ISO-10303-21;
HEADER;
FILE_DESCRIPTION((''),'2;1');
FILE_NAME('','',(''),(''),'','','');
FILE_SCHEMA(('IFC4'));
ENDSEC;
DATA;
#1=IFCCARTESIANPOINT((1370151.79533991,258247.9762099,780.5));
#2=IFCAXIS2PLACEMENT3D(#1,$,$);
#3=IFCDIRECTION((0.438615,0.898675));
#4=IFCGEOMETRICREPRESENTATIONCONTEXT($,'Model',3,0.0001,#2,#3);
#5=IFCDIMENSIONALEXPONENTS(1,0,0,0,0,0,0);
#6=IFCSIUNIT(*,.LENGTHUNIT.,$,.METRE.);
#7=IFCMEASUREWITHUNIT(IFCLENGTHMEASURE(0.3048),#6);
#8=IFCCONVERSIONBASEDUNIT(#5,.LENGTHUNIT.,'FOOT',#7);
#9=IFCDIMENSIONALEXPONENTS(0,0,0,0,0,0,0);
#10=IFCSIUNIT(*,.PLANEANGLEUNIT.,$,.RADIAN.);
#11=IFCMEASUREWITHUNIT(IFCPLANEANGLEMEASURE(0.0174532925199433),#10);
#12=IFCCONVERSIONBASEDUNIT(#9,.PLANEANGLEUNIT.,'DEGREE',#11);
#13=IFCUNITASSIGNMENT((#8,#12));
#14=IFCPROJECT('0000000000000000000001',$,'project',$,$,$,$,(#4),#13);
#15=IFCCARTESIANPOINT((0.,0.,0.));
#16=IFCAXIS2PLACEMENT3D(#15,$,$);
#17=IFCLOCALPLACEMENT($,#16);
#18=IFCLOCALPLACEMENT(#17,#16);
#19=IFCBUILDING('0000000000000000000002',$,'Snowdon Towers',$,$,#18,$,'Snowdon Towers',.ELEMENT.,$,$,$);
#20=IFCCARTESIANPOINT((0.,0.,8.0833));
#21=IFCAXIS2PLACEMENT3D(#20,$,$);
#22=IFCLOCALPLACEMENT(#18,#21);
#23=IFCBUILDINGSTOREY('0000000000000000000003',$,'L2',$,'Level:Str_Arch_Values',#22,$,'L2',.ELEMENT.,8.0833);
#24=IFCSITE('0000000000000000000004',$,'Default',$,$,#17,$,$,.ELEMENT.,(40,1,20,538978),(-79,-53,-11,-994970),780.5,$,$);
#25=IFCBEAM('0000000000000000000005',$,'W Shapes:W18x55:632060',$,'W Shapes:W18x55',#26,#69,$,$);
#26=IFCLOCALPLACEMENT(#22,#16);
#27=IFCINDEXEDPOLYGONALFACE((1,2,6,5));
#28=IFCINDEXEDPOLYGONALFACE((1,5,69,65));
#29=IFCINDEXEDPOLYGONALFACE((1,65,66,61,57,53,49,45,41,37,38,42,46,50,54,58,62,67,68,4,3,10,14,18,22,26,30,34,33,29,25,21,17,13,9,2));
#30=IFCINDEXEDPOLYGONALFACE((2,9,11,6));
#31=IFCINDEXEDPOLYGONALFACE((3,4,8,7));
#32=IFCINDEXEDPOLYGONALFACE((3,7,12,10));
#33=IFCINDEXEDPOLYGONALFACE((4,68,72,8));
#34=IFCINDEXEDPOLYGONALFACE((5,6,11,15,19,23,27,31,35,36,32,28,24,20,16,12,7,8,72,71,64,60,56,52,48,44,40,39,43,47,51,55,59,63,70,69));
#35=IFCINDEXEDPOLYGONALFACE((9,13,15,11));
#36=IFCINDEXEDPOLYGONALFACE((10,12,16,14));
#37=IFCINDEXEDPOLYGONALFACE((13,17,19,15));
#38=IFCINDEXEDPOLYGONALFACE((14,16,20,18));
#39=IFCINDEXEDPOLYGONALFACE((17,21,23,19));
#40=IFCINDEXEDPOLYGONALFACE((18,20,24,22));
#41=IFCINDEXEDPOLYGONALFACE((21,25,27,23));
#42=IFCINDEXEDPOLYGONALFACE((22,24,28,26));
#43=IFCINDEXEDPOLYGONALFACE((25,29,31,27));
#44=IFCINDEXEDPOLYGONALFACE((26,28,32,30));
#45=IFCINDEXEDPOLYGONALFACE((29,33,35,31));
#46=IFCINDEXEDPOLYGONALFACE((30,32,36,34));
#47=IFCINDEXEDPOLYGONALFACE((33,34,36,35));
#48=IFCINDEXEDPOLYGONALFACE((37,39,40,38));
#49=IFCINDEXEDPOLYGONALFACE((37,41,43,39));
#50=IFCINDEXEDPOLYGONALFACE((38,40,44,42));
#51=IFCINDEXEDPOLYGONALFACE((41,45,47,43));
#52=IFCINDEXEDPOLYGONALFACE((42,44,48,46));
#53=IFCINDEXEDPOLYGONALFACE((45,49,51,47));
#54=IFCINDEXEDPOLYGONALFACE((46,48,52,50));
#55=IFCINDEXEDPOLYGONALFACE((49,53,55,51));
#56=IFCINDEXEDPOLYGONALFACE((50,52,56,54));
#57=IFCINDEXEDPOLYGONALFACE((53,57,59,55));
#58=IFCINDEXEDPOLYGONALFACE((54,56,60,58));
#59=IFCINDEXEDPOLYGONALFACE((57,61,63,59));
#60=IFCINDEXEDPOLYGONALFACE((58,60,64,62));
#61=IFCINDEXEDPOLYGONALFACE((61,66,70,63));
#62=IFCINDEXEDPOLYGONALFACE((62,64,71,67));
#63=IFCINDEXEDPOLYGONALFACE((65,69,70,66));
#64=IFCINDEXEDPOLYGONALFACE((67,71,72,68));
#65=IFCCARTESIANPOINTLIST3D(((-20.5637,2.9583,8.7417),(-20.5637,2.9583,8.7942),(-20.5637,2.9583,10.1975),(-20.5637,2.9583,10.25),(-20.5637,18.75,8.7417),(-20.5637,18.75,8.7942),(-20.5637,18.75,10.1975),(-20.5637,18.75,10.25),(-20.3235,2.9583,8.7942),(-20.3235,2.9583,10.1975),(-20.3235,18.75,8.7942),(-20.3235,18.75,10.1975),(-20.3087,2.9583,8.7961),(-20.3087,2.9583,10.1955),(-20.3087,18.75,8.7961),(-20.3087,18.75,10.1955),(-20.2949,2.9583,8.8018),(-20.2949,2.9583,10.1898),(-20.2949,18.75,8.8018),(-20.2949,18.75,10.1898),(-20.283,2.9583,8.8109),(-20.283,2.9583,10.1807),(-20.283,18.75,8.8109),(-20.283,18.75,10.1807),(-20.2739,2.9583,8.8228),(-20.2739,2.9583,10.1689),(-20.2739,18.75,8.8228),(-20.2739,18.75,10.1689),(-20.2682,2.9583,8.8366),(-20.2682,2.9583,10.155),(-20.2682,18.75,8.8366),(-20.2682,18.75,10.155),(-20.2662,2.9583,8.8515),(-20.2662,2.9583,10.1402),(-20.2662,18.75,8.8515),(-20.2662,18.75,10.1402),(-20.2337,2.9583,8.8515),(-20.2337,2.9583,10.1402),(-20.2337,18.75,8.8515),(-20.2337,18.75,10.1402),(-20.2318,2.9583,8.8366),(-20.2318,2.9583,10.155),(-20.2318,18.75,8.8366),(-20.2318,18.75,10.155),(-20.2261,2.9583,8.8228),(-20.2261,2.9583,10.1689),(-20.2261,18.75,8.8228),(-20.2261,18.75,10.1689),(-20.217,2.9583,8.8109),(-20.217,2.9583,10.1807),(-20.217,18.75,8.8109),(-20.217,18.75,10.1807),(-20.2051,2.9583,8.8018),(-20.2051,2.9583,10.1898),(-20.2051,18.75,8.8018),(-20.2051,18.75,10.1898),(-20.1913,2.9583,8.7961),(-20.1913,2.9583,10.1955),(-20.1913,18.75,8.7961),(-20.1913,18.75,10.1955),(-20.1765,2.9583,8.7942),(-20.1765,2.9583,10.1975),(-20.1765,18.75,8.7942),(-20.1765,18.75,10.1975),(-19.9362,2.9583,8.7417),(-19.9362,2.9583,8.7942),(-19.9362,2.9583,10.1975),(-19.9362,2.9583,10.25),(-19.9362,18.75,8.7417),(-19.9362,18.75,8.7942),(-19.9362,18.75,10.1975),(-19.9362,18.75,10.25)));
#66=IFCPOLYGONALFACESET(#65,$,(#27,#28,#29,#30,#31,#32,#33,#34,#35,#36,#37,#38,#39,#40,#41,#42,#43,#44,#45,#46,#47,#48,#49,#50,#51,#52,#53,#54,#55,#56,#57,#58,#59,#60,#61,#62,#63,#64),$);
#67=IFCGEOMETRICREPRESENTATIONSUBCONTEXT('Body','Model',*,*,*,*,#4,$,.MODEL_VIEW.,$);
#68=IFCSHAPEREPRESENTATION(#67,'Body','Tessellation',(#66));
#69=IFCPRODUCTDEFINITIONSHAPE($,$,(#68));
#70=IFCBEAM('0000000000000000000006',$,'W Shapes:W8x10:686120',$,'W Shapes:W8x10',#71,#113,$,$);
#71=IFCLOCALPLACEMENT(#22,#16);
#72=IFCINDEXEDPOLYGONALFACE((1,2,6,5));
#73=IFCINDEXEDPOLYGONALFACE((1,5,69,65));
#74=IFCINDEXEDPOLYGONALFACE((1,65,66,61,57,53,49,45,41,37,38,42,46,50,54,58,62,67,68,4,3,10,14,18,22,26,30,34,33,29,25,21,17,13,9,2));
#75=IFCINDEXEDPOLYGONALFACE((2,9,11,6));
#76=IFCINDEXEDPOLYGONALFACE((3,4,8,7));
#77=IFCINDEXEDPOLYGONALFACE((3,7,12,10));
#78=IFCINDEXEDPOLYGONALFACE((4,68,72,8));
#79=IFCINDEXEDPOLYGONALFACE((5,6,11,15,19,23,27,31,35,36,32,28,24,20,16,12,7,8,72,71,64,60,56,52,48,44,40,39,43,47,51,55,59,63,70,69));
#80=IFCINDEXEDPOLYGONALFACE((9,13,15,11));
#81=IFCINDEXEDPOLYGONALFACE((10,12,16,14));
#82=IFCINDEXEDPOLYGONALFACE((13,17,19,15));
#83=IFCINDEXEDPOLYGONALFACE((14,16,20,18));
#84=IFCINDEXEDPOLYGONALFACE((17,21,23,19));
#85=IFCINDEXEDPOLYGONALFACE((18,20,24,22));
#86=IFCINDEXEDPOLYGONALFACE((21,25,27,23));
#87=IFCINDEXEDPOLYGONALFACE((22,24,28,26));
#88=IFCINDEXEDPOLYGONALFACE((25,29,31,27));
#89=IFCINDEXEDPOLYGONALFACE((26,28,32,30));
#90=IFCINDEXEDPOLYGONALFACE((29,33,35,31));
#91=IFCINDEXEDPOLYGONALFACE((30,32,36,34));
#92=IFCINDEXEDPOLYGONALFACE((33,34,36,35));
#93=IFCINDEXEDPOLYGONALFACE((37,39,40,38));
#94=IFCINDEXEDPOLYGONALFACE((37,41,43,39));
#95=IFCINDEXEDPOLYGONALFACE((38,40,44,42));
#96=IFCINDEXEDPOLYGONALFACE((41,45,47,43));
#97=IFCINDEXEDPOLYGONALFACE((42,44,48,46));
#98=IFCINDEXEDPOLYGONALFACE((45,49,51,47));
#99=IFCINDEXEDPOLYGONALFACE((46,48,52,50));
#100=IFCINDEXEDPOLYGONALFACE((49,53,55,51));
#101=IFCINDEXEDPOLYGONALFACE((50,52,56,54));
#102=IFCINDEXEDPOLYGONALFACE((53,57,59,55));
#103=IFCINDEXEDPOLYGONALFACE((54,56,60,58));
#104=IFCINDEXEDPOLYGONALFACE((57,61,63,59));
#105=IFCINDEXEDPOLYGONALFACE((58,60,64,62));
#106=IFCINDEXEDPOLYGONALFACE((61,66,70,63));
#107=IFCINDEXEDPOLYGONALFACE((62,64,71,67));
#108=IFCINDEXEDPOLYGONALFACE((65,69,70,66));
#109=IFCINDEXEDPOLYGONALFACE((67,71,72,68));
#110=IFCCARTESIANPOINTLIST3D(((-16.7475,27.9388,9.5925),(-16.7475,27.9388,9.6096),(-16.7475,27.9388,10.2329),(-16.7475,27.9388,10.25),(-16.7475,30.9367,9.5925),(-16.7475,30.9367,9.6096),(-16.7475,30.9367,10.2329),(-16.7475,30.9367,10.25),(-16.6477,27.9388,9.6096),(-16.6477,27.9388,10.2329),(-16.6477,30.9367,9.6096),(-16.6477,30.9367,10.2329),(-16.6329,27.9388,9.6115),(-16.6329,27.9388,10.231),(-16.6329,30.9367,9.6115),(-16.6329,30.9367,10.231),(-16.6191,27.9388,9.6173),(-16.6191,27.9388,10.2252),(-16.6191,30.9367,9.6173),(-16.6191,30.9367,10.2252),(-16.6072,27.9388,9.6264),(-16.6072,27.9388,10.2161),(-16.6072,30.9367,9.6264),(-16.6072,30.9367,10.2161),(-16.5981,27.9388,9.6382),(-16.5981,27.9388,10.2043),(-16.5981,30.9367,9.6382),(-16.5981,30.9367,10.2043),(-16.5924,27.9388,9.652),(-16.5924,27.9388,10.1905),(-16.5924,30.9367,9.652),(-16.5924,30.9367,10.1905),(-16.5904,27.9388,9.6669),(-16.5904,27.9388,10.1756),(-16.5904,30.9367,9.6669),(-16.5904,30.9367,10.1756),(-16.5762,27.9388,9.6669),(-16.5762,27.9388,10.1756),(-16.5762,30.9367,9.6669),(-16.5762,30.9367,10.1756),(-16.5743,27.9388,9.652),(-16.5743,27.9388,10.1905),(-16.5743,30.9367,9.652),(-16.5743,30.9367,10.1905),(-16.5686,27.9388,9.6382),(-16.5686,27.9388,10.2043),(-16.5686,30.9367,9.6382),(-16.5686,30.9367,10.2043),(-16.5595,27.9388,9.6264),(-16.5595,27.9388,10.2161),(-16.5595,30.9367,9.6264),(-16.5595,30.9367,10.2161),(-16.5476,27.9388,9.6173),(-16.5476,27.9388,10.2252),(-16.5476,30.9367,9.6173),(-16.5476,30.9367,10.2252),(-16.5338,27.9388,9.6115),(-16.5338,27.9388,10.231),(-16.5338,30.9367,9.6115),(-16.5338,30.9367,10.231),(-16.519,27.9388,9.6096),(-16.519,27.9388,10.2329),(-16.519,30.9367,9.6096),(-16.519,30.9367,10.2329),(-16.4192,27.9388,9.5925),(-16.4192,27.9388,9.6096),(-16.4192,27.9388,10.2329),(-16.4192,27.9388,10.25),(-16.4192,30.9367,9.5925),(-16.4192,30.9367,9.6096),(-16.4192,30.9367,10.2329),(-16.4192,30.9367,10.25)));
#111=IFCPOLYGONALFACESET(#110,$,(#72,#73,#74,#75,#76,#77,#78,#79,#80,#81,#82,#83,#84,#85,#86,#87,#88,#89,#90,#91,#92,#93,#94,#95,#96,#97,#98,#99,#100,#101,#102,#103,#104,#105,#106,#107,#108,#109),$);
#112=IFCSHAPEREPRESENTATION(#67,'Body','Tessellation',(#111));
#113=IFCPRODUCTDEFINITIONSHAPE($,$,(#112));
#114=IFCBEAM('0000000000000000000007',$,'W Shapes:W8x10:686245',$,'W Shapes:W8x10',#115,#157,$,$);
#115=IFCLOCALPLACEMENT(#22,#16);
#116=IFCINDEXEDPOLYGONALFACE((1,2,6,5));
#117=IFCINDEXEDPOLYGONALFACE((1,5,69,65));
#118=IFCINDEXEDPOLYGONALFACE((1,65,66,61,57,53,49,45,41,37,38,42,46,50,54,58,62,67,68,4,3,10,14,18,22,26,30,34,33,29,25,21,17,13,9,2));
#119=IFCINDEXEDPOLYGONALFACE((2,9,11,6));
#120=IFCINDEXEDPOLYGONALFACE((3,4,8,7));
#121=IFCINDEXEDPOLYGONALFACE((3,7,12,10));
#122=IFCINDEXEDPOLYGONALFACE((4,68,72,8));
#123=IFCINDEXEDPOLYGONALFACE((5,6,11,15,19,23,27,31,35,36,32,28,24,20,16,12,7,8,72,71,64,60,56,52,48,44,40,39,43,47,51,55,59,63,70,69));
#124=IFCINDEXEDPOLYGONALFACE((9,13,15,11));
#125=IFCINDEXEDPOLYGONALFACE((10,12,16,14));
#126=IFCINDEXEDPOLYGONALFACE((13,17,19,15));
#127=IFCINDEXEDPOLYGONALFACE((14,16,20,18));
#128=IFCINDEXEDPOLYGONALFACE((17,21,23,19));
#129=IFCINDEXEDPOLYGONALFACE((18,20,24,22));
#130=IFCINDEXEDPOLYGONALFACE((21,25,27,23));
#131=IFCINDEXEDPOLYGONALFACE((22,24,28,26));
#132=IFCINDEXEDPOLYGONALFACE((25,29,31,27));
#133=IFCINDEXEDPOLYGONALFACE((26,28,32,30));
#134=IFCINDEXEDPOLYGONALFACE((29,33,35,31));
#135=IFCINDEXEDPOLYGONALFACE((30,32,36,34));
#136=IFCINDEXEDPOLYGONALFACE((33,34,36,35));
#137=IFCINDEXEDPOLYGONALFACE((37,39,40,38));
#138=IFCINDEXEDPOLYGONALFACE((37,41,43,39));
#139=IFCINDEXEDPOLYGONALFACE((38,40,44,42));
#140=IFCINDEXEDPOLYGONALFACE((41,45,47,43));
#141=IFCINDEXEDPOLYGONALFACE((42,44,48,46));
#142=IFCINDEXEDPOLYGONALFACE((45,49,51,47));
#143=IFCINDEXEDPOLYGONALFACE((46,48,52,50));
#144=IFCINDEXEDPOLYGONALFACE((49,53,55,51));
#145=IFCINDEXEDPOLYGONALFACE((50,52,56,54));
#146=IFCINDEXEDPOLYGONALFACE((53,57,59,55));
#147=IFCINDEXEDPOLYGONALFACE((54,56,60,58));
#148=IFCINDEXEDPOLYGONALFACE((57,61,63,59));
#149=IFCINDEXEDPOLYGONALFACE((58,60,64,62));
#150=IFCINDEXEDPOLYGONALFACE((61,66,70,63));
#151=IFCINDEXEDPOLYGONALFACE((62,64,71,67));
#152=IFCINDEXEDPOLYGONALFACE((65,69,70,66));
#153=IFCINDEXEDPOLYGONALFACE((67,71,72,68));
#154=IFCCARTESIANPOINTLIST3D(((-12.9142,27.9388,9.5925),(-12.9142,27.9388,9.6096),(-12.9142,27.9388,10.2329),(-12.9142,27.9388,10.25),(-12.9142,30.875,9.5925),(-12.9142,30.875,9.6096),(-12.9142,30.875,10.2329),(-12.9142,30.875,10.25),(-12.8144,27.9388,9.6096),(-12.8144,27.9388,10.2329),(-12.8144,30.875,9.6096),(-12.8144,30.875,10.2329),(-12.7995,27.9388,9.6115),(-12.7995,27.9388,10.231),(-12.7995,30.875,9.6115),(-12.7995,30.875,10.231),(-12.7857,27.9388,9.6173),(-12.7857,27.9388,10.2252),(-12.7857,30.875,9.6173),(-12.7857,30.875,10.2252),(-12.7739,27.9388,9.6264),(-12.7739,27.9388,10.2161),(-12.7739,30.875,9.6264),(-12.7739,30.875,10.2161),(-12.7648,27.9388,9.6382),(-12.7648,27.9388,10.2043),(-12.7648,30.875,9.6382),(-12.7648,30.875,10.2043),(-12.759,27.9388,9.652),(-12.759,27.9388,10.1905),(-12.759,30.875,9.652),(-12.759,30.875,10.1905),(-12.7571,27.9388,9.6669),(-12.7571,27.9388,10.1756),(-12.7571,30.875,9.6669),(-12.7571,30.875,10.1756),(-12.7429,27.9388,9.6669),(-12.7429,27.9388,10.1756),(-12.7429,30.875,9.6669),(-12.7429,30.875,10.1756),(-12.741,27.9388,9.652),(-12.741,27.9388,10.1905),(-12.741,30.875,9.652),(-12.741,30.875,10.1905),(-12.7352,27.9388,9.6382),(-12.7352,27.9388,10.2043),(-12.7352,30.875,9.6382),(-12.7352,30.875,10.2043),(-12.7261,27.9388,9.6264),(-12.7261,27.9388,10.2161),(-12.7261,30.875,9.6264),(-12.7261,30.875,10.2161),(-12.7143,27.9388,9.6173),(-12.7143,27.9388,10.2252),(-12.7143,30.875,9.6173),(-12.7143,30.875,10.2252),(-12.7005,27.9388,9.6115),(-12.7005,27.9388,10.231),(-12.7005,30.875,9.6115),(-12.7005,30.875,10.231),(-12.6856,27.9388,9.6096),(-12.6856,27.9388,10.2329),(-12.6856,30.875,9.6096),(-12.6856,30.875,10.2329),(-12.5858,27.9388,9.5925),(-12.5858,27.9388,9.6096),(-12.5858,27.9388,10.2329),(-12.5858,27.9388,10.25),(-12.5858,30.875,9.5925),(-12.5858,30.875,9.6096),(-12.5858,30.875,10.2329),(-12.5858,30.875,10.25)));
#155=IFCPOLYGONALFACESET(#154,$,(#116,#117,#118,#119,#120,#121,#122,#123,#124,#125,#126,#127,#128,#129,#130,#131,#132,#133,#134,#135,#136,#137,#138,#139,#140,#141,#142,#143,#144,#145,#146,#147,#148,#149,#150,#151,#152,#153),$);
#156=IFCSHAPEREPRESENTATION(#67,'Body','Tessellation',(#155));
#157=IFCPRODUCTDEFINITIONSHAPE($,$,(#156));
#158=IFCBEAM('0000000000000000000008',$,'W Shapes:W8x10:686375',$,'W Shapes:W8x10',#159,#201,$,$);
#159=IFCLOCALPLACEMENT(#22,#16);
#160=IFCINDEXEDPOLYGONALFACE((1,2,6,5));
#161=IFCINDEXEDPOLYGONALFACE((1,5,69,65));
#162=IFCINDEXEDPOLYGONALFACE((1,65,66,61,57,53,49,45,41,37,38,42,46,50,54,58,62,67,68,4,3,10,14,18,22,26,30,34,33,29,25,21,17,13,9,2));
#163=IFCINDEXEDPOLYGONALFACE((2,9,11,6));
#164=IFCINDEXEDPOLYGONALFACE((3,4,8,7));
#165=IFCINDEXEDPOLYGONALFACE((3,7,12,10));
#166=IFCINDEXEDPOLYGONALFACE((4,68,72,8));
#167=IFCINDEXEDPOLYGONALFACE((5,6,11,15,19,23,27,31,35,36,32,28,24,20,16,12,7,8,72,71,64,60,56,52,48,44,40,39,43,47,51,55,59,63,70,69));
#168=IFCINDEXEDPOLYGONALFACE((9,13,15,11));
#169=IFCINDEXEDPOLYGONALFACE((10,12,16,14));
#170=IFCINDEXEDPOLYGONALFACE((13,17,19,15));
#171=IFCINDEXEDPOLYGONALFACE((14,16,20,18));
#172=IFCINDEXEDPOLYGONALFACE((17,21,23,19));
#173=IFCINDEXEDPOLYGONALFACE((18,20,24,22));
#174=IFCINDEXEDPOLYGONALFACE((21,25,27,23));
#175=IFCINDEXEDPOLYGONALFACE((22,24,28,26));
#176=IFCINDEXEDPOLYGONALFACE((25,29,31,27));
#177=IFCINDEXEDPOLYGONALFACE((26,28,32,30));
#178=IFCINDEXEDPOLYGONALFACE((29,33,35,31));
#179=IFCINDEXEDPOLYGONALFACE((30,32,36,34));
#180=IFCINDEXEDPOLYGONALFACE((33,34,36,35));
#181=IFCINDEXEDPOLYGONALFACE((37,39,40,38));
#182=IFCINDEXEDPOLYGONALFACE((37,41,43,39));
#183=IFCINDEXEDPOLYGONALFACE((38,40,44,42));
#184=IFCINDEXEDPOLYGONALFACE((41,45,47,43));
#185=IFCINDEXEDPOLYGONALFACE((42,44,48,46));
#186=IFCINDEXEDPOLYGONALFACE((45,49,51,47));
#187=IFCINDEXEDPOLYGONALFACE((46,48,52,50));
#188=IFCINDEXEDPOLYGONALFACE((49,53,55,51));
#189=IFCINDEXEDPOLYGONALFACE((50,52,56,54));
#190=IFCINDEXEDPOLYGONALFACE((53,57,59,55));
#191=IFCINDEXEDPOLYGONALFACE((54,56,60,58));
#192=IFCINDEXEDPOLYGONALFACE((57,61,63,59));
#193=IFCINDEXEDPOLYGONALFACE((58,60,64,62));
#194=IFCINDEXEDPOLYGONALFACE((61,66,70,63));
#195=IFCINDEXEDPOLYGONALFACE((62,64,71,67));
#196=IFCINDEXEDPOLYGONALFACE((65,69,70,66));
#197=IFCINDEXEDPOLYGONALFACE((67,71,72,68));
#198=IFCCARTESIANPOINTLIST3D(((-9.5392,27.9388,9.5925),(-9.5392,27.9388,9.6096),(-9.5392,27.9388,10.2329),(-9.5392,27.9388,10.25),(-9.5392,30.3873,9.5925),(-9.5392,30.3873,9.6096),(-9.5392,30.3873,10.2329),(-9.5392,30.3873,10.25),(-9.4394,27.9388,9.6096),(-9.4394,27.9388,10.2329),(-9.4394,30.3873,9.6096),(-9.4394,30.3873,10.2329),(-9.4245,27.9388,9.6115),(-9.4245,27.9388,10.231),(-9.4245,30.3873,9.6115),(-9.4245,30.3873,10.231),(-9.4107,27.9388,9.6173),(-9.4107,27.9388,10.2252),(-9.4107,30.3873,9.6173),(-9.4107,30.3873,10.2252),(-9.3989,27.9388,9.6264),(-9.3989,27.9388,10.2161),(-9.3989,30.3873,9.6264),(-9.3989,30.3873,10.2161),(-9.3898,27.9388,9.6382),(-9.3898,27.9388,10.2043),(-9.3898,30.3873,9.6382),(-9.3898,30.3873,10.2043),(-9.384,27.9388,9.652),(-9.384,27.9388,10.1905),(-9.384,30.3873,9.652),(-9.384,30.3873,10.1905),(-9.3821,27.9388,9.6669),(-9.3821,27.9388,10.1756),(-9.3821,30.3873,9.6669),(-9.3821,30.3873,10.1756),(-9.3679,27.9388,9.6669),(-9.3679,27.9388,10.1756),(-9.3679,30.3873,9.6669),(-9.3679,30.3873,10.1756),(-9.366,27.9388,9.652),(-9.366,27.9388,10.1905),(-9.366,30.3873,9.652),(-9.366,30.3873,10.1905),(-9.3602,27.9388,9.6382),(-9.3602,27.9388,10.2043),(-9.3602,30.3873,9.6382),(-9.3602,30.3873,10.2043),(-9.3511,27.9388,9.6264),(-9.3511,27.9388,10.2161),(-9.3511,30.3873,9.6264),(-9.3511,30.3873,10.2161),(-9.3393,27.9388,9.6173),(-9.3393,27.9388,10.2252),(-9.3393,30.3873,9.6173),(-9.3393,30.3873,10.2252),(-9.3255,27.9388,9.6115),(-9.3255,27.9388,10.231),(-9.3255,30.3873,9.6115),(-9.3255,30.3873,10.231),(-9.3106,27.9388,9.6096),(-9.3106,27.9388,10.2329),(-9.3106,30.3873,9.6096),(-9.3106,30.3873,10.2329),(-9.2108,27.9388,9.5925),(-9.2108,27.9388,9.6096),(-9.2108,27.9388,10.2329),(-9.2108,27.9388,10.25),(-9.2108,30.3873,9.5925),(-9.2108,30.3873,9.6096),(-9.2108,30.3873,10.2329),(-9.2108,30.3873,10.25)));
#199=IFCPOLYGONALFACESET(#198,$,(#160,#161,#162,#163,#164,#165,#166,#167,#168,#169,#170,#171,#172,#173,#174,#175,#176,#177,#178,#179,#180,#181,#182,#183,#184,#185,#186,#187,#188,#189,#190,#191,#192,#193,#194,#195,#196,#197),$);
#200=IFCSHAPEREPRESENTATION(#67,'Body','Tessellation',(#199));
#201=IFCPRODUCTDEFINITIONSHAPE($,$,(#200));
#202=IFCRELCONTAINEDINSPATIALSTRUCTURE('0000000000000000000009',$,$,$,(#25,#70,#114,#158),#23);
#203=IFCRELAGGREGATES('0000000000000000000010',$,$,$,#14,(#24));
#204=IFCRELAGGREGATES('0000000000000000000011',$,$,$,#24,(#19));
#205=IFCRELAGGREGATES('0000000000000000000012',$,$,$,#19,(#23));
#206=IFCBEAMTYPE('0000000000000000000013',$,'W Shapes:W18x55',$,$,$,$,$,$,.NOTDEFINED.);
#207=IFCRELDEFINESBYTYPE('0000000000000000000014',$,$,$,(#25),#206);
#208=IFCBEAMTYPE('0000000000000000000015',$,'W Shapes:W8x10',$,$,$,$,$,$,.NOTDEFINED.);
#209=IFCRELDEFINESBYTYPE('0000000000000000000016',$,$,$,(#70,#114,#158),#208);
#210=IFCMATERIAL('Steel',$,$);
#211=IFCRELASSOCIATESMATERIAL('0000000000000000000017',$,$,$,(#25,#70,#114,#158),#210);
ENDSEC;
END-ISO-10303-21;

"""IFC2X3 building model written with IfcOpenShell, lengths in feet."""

from ifc_helpers import new_model, entity, si_unit, converted_unit, direction, frame, frame_2d, origin, place, context, subcontext, project, spatial, i_section, extrude, material, type_object, element, save


model = new_model("IFC2X3")

# Units and contexts
model_context = context("Model", 3, precision=0.0001, world=frame((1370151.79533991, 258247.9762099, 780.5)), true_north=direction((0.438615, 0.898675)))
body_context = subcontext(model_context, "Body", "Model", "MODEL_VIEW")
ifc_project = project(units=[converted_unit("LENGTHUNIT", "FOOT", entity("IfcLengthMeasure", 0.3048), si_unit("LENGTHUNIT", "METRE"), dimensions=[1, 0, 0, 0, 0, 0, 0]), converted_unit("PLANEANGLEUNIT", "DEGREE", entity("IfcPlaneAngleMeasure", 0.0174532925199433), si_unit("PLANEANGLEUNIT", "RADIAN"), dimensions=[0, 0, 0, 0, 0, 0, 0])], contexts=[model_context])

# Site, building, storey
site_placement = place(None, origin())
site = spatial("IfcSite", under=ifc_project, at=site_placement, Name="Default", CompositionType="ELEMENT", RefLatitude=(40, 1, 20, 538978), RefLongitude=(-79, -53, -11, -994970), RefElevation=780.5)
building_placement = place(site_placement, origin())
building = spatial("IfcBuilding", under=site, at=building_placement, Name="Snowdon Towers", LongName="Snowdon Towers", CompositionType="ELEMENT")
storey_placement = place(building_placement, frame((0.0, 0.0, 8.0833)))
storey = spatial("IfcBuildingStorey", under=building, at=storey_placement, Name="L2", ObjectType="Level:Str_Arch_Values", LongName="L2", CompositionType="ELEMENT", Elevation=8.0833)

# Beam
ifc_material_1 = material(Name="Steel")
beam_type_1 = type_object("IfcBeamType", Name="W Shapes:W18x55", PredefinedType="NOTDEFINED")
beam_1_placement = place(storey_placement, frame((-20.25, 19.2083, 10.25), z_axis=(0.0, 0.0, 1.0), x_axis=(0.0, -1.0, 0.0)))
element("IfcBeam", 1, at=beam_1_placement, inside=storey, type_object=beam_type_1, material=ifc_material_1, Name="W Shapes:W18x55:632060", ObjectType="W Shapes:W18x55", context=body_context, shape_type="SweptSolid", body=[
    extrude(i_section(OverallWidth=0.6275, OverallDepth=1.5083, WebThickness=0.0325, FlangeThickness=0.0525, FilletRadius=0.0573, at=frame_2d((0.0, 0.0), x_axis=(0.0, 1.0))), frame((0.4583, 0.0, -0.7542), z_axis=(1.0, 0.0, 0.0), x_axis=(0.0, 0.0, -1.0)), (0.0, 0.0, 1.0), 15.7917),
])

# Shared definitions
beam_type_2 = type_object("IfcBeamType", Name="W Shapes:W8x10", PredefinedType="NOTDEFINED")

# Beams
beam_2_placement = place(storey_placement, frame((-16.7475, 27.625, 10.25), z_axis=(0.0, 0.0, 1.0), x_axis=(0.0, 1.0, 0.0)))
element("IfcBeam", 2, at=beam_2_placement, inside=storey, type_object=beam_type_2, material=ifc_material_1, Name="W Shapes:W8x10:686120", ObjectType="W Shapes:W8x10", context=body_context, shape_type="SweptSolid", body=[
    extrude(i_section(OverallWidth=0.3283, OverallDepth=0.6575, WebThickness=0.0142, FlangeThickness=0.0171, FilletRadius=0.0573, at=frame_2d((0.0, 0.0), x_axis=(0.0, 1.0))), frame((0.3137, -0.1642, -0.3288), z_axis=(1.0, 0.0, 0.0), x_axis=(0.0, 0.0, -1.0)), (0.0, 0.0, 1.0), 2.9979),
])
beam_3_placement = place(storey_placement, frame((-12.75, 27.625, 10.25), z_axis=(0.0, 0.0, 1.0), x_axis=(0.0, 1.0, 0.0)))
element("IfcBeam", 3, at=beam_3_placement, inside=storey, type_object=beam_type_2, material=ifc_material_1, Name="W Shapes:W8x10:686245", ObjectType="W Shapes:W8x10", context=body_context, shape_type="SweptSolid", body=[
    extrude(i_section(OverallWidth=0.3283, OverallDepth=0.6575, WebThickness=0.0142, FlangeThickness=0.0171, FilletRadius=0.0573, at=frame_2d((0.0, 0.0), x_axis=(0.0, 1.0))), frame((0.3137, 0.0, -0.3288), z_axis=(1.0, 0.0, 0.0), x_axis=(0.0, 0.0, -1.0)), (0.0, 0.0, 1.0), 2.9363),
])
beam_4_placement = place(storey_placement, frame((-9.375, 27.625, 10.25), z_axis=(0.0, 0.0, 1.0), x_axis=(0.0, 1.0, 0.0)))
element("IfcBeam", 4, at=beam_4_placement, inside=storey, type_object=beam_type_2, material=ifc_material_1, Name="W Shapes:W8x10:686375", ObjectType="W Shapes:W8x10", context=body_context, shape_type="SweptSolid", body=[
    extrude(i_section(OverallWidth=0.3283, OverallDepth=0.6575, WebThickness=0.0142, FlangeThickness=0.0171, FilletRadius=0.0573, at=frame_2d((0.0, 0.0), x_axis=(0.0, 1.0))), frame((0.3137, 0.0, -0.3288), z_axis=(1.0, 0.0, 0.0), x_axis=(0.0, 0.0, -1.0)), (0.0, 0.0, 1.0), 2.4485),
])

save(model, "model.ifc")
